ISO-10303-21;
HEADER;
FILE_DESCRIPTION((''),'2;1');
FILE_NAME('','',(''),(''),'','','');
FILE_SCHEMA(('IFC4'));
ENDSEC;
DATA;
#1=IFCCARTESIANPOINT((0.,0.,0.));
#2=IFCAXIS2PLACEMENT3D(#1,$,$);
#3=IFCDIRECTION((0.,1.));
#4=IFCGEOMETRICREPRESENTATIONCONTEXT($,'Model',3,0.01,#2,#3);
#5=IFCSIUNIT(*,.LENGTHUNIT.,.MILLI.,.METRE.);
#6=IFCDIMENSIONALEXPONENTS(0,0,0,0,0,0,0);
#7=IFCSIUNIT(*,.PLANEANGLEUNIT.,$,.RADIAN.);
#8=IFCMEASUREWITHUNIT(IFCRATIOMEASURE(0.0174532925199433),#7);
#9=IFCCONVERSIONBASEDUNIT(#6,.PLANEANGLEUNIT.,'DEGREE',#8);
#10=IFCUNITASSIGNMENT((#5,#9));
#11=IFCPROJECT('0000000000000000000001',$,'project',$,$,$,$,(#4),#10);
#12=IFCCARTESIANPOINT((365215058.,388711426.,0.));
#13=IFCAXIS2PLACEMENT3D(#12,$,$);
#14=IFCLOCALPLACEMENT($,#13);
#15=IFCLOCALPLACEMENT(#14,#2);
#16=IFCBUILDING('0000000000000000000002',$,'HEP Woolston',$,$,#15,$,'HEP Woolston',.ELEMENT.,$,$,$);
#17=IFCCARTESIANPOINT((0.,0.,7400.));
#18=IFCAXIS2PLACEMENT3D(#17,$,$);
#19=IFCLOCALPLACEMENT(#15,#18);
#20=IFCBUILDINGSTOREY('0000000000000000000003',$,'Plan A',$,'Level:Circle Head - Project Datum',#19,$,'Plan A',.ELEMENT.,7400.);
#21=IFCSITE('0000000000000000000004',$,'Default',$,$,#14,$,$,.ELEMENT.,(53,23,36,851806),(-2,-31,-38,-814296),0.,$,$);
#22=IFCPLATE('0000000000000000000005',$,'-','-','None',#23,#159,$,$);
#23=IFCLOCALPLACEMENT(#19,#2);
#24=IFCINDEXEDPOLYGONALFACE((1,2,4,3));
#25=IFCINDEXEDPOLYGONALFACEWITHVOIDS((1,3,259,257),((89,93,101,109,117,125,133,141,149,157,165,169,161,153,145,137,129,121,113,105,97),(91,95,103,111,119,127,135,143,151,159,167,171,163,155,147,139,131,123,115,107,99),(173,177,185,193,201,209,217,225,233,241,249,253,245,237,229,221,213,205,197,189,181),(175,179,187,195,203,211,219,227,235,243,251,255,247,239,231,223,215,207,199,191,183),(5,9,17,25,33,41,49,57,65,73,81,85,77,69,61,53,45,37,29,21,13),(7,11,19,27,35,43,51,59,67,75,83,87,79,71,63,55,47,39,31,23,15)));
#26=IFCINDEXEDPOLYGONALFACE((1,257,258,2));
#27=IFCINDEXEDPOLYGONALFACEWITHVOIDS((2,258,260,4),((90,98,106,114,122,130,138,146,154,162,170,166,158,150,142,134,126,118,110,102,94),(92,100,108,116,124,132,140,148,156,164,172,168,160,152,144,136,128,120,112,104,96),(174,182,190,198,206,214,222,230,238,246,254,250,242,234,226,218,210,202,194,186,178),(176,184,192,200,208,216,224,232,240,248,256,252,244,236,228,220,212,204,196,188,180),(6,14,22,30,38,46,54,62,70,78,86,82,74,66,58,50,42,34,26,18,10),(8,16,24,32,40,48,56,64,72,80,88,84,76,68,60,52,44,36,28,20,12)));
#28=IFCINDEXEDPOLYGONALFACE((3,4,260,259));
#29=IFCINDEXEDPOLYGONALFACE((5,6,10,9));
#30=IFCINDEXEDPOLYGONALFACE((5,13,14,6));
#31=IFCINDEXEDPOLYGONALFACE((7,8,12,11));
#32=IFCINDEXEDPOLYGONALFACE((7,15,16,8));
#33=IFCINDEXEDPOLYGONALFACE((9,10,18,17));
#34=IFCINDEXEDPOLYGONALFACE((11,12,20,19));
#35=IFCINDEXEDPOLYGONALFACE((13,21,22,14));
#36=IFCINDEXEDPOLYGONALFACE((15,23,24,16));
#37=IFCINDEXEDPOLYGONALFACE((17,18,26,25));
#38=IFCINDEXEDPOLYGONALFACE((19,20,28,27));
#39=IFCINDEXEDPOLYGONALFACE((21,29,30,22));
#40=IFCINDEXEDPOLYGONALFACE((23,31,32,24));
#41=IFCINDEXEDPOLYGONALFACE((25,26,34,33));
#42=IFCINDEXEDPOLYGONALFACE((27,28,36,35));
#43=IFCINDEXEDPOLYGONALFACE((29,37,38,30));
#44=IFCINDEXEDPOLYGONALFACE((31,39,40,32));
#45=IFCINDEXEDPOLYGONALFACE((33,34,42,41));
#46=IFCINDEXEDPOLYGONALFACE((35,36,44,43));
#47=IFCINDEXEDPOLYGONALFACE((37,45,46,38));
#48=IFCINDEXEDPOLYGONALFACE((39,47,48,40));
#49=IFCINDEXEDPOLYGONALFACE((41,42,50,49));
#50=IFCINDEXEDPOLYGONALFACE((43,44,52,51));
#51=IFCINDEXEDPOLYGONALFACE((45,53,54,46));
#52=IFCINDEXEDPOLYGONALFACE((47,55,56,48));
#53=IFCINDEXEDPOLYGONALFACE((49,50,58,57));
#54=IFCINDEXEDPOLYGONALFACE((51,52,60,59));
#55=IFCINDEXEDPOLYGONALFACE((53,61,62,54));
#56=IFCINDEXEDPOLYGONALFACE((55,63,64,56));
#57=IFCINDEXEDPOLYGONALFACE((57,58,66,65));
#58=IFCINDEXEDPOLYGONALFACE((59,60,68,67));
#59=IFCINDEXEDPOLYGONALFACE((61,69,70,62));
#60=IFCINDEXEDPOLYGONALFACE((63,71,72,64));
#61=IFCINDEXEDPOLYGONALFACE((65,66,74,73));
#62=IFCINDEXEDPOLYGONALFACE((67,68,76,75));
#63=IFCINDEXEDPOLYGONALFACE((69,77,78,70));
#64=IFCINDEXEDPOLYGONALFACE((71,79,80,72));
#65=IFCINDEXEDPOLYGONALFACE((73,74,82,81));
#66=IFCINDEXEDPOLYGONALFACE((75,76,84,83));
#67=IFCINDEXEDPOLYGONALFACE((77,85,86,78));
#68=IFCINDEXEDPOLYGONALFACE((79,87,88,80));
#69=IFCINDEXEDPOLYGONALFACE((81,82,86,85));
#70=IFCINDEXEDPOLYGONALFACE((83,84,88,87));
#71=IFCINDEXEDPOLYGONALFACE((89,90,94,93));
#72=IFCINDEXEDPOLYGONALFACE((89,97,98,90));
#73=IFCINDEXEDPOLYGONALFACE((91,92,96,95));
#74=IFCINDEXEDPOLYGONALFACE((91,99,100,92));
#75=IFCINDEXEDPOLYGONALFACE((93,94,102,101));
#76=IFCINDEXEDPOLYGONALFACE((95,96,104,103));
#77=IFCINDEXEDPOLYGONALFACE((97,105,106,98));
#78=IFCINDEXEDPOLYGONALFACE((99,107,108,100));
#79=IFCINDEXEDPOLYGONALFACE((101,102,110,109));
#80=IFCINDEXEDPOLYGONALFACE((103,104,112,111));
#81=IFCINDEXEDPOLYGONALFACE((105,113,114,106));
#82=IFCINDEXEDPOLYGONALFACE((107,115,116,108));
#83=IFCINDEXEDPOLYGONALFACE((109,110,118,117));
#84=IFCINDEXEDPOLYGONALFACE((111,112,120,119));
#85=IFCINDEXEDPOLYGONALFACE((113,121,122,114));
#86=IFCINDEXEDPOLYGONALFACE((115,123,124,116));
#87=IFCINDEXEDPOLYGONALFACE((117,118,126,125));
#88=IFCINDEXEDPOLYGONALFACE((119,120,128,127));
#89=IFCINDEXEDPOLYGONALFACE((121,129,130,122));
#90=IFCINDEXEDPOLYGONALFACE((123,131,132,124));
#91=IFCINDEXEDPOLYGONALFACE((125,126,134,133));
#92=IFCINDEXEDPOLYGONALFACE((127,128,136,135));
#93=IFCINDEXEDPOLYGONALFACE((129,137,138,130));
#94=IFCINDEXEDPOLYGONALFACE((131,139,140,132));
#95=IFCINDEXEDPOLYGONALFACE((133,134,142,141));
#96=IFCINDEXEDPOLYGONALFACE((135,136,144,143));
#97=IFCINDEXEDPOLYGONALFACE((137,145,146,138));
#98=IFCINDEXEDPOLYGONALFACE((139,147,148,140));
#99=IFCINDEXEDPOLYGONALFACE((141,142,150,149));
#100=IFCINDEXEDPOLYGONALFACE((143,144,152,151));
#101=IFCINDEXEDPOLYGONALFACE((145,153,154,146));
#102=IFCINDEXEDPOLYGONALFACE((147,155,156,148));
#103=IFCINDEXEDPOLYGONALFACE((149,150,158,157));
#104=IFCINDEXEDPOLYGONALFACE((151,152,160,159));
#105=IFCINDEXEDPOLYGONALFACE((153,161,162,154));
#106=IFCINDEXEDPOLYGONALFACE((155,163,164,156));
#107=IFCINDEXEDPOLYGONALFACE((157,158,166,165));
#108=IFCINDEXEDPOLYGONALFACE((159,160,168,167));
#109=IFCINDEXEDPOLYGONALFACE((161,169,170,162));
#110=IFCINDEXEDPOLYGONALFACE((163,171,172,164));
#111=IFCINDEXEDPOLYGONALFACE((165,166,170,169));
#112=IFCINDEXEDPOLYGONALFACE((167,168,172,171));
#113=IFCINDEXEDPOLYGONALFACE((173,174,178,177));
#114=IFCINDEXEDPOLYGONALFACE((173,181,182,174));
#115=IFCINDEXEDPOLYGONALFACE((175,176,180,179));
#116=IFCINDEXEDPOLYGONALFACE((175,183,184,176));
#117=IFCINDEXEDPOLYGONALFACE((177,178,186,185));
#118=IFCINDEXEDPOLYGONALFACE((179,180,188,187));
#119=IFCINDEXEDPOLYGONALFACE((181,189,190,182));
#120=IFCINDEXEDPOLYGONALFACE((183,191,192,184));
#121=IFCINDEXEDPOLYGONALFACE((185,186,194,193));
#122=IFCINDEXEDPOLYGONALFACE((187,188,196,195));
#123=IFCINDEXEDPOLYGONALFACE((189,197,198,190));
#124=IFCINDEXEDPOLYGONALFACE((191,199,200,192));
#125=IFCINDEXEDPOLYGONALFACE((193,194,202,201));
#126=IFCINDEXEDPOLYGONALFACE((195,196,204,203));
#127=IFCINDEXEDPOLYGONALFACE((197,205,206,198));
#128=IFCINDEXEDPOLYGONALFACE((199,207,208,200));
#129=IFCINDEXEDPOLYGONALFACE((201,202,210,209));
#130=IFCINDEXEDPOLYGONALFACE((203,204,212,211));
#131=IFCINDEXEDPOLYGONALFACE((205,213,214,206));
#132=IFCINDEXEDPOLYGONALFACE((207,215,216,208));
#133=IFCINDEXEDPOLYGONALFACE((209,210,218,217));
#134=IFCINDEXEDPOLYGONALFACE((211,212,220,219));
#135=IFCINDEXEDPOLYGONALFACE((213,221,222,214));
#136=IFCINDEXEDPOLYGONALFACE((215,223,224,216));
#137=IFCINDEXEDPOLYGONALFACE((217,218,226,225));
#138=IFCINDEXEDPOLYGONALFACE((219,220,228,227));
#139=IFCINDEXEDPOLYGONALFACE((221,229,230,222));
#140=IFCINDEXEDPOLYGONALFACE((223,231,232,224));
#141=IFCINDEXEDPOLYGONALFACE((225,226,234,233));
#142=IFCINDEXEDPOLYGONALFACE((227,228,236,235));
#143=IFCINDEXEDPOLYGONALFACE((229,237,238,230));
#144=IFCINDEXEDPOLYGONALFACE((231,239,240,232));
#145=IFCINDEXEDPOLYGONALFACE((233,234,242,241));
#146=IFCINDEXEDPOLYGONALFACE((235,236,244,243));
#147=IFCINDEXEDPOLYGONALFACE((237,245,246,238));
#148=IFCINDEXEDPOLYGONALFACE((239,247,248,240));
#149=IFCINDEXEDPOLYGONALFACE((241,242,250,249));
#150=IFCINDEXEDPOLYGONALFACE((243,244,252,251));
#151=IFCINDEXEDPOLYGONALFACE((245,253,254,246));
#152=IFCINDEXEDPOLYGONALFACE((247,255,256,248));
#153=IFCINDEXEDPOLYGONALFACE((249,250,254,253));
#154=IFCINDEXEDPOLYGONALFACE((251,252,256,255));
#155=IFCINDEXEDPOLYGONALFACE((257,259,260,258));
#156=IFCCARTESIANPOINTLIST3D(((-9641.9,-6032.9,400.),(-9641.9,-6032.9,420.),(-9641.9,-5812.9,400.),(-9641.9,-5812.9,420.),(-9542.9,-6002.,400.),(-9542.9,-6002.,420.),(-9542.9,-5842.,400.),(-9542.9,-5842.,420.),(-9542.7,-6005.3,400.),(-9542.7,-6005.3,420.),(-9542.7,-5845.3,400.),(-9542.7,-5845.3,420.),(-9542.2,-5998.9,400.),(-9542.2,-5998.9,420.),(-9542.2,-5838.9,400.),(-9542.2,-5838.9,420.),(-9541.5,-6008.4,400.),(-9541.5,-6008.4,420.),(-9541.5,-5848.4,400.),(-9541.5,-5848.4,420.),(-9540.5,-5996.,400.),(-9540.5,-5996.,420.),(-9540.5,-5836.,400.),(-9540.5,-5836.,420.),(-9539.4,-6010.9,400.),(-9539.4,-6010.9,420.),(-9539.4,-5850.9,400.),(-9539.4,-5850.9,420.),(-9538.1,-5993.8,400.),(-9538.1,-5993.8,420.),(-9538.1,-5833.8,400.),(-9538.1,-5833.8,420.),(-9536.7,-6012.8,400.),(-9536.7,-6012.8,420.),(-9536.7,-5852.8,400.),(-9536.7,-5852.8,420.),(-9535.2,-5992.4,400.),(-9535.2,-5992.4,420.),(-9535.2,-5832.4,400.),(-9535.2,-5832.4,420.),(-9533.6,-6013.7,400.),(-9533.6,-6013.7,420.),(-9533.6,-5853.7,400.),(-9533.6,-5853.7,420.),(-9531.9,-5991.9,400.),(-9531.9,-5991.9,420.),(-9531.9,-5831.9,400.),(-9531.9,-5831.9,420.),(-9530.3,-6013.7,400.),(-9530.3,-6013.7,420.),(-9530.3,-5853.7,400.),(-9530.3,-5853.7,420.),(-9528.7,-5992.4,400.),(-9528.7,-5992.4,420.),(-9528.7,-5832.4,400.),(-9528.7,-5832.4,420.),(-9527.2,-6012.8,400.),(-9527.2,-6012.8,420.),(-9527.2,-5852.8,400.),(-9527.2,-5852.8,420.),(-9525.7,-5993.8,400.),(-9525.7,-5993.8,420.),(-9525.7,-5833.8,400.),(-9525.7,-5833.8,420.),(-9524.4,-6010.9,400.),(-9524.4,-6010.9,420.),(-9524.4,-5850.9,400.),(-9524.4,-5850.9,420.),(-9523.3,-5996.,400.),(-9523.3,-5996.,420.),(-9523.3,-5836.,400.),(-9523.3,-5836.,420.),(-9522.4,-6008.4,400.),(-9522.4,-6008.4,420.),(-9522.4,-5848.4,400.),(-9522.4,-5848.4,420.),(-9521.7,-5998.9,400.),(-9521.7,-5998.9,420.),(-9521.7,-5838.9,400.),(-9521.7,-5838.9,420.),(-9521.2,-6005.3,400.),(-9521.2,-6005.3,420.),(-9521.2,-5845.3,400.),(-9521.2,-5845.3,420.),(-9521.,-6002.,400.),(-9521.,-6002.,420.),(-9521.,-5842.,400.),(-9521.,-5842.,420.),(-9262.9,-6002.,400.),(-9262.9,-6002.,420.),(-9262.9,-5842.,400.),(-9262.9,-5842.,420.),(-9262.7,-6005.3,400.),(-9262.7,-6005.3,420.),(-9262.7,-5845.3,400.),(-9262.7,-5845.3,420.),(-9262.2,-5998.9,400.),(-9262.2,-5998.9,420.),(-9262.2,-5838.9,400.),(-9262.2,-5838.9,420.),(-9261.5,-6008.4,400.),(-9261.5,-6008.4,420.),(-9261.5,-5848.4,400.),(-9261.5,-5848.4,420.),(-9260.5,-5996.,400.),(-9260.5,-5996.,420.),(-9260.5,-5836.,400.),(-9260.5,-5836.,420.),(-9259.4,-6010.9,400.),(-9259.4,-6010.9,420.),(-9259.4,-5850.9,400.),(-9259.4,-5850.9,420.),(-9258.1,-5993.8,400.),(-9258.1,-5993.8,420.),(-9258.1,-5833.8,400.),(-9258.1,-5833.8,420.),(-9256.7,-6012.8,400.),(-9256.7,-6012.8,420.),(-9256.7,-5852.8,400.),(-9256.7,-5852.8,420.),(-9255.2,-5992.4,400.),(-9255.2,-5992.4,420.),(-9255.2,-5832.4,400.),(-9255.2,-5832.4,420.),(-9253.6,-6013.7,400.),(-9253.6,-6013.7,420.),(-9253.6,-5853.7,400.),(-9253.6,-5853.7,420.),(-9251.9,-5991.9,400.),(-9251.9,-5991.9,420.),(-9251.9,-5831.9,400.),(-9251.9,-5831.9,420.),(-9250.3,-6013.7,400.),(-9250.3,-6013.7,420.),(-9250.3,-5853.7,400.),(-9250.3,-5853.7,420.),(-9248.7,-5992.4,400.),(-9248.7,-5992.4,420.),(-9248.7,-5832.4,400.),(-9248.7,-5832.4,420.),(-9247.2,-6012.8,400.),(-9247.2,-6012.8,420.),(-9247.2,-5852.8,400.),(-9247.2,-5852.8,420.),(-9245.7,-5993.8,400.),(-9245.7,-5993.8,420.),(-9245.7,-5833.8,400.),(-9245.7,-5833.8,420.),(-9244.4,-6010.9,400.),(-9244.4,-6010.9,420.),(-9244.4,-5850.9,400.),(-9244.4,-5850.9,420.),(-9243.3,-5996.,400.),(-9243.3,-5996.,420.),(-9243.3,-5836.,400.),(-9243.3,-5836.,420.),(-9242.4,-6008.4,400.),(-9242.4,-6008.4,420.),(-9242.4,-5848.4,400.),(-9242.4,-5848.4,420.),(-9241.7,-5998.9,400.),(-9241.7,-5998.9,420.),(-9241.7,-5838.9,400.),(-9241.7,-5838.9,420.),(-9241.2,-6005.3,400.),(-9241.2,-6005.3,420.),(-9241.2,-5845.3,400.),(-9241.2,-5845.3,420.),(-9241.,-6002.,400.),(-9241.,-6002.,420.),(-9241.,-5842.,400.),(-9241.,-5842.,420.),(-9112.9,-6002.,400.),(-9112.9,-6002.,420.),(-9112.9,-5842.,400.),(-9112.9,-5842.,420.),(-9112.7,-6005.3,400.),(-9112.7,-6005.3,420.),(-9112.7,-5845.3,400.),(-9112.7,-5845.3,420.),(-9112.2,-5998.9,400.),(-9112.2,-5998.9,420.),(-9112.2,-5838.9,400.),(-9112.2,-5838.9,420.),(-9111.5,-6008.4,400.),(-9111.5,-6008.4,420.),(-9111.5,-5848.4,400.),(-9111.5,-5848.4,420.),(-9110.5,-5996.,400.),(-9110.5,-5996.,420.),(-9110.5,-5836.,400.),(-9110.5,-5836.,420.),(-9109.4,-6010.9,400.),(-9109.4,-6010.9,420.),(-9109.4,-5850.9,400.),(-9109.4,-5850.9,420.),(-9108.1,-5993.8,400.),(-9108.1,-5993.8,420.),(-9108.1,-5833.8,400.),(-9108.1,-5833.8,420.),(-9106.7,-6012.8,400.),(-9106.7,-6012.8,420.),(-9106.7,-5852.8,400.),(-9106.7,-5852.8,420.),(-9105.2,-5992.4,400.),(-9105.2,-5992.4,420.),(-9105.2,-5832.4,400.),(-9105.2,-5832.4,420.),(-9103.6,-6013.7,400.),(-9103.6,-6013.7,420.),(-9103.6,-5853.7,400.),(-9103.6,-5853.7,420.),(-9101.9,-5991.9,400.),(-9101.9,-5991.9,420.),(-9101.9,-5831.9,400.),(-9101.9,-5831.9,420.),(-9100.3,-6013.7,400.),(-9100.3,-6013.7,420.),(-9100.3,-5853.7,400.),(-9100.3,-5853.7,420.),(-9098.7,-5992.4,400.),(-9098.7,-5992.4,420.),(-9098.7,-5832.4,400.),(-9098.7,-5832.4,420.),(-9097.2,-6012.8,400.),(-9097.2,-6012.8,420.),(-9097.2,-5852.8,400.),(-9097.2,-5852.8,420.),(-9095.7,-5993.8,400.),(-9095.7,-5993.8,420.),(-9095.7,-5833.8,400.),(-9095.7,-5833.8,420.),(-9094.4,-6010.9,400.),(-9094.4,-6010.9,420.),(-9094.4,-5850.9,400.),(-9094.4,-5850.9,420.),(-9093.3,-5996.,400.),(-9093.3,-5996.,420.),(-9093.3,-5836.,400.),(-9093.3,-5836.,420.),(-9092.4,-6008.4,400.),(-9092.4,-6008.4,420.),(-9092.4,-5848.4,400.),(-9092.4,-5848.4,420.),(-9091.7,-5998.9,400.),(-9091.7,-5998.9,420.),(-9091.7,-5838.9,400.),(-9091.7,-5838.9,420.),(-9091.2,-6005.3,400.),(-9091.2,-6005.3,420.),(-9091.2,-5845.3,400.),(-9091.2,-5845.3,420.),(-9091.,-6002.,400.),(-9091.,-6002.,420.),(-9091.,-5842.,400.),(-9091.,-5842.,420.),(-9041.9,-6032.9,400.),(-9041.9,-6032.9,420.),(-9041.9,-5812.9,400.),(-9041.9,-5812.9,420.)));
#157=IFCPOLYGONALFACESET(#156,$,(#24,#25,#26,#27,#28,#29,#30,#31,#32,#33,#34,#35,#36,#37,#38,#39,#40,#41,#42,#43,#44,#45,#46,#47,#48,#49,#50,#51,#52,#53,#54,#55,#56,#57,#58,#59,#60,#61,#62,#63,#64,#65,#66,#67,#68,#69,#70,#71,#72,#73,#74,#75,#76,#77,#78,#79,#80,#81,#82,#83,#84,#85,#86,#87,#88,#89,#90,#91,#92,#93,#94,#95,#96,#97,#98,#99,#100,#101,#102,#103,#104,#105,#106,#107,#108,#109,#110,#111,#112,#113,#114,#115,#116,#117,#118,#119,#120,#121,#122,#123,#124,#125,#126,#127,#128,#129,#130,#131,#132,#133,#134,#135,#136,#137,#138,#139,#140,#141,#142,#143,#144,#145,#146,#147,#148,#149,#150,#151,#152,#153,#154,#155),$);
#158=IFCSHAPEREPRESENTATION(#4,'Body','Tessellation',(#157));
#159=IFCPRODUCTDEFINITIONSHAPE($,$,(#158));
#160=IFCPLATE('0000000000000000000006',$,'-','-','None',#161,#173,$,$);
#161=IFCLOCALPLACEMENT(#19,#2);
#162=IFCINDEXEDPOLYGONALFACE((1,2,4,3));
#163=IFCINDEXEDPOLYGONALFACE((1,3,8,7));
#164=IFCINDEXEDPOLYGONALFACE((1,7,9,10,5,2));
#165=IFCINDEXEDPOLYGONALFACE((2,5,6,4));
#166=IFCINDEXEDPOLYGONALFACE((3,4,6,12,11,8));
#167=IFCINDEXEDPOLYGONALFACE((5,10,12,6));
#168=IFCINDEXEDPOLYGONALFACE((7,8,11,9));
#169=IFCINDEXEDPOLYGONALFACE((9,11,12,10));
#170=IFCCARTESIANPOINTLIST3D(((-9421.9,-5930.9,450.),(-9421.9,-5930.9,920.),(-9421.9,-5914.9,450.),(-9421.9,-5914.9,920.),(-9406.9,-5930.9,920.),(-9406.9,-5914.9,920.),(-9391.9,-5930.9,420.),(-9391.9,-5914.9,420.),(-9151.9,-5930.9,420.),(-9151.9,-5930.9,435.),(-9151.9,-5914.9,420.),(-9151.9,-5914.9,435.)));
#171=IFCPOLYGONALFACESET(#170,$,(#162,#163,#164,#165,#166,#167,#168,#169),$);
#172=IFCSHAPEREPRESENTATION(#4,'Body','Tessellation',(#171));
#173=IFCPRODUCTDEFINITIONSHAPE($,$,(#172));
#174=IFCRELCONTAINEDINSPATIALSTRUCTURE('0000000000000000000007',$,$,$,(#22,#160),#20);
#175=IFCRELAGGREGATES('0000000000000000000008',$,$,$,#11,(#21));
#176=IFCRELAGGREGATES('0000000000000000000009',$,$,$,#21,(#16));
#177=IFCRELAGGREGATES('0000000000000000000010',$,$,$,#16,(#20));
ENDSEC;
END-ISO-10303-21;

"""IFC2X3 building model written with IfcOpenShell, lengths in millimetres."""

from ifc_helpers import new_model, entity, si_unit, converted_unit, direction, frame, frame_2d, origin, origin_with_axes, place, context, project, spatial, polyline, circle, outline, extrude, element, save


model = new_model("IFC2X3")

# Units and contexts
model_context = context("Model", 3, precision=0.01, world=origin(), true_north=direction((0.0, 1.0)))
ifc_project = project(units=[si_unit("LENGTHUNIT", "METRE", prefix="MILLI"), converted_unit("PLANEANGLEUNIT", "DEGREE", entity("IfcRatioMeasure", 0.0174532925199433), si_unit("PLANEANGLEUNIT", "RADIAN"), dimensions=[0, 0, 0, 0, 0, 0, 0])], contexts=[model_context])

# Site, building, storey
site_placement = place(None, frame((365215058.0, 388711426.0, 0.0)))
site = spatial("IfcSite", under=ifc_project, at=site_placement, Name="Default", CompositionType="ELEMENT", RefLatitude=(53, 23, 36, 851806), RefLongitude=(-2, -31, -38, -814296), RefElevation=0.0)
building_placement = place(site_placement, origin())
building = spatial("IfcBuilding", under=site, at=building_placement, Name="HEP Woolston", LongName="HEP Woolston", CompositionType="ELEMENT")
storey_placement = place(building_placement, frame((0.0, 0.0, 7400.0)))
storey = spatial("IfcBuildingStorey", under=building, at=storey_placement, Name="Plan A", ObjectType="Level:Circle Head - Project Datum", LongName="Plan A", CompositionType="ELEMENT", Elevation=7400.0)

# Plate, openings
plate_1_placement = place(storey_placement, frame((-9041.9, -5812.9, 400.0)))
plate_1 = element("IfcPlate", 1, at=plate_1_placement, inside=storey, Name="-", Description="-", ObjectType="None", context=model_context, shape_type="SweptSolid", body=[
    extrude(outline(polyline([(0.0, 0.0), (-600.0, 0.0), (-600.0, -220.0), (0.0, -220.0), (0.0, 0.0)])), origin_with_axes(), (0.0, 0.0, 1.0), 20.0),
])
opening_1_placement = place(plate_1_placement, frame((-490.0, -110.0, -0.5), z_axis=(0.0, 0.0, 1.0), x_axis=(0.0, 1.0, 0.0)))
element("IfcOpeningElement", 2, at=opening_1_placement, cuts=plate_1, ObjectType="Opening", context=model_context, shape_type="SweptSolid", body=[
    extrude(circle(Radius=11.0, at=frame_2d((80.0, 0.0), x_axis=(1.0, 0.0))), origin(), (0.0, 0.0, 1.0), 21.0),
])
opening_2_placement = place(plate_1_placement, frame((-490.0, -110.0, -0.5), z_axis=(0.0, 0.0, 1.0), x_axis=(0.0, 1.0, 0.0)))
element("IfcOpeningElement", 3, at=opening_2_placement, cuts=plate_1, ObjectType="Opening", context=model_context, shape_type="SweptSolid", body=[
    extrude(circle(Radius=11.0, at=frame_2d((-80.0, 0.0), x_axis=(1.0, 0.0))), origin(), (0.0, 0.0, 1.0), 21.0),
])
opening_3_placement = place(plate_1_placement, frame((-135.0, -110.0, -0.5), z_axis=(0.0, 0.0, 1.0), x_axis=(0.0, 1.0, 0.0)))
element("IfcOpeningElement", 4, at=opening_3_placement, cuts=plate_1, ObjectType="Opening", context=model_context, shape_type="SweptSolid", body=[
    extrude(circle(Radius=11.0, at=frame_2d((80.0, 75.0), x_axis=(1.0, 0.0))), origin(), (0.0, 0.0, 1.0), 21.0),
])
opening_4_placement = place(plate_1_placement, frame((-135.0, -110.0, -0.5), z_axis=(0.0, 0.0, 1.0), x_axis=(0.0, 1.0, 0.0)))
element("IfcOpeningElement", 5, at=opening_4_placement, cuts=plate_1, ObjectType="Opening", context=model_context, shape_type="SweptSolid", body=[
    extrude(circle(Radius=11.0, at=frame_2d((-80.0, 75.0), x_axis=(1.0, 0.0))), origin(), (0.0, 0.0, 1.0), 21.0),
])
opening_5_placement = place(plate_1_placement, frame((-135.0, -110.0, -0.5), z_axis=(0.0, 0.0, 1.0), x_axis=(0.0, 1.0, 0.0)))
element("IfcOpeningElement", 6, at=opening_5_placement, cuts=plate_1, ObjectType="Opening", context=model_context, shape_type="SweptSolid", body=[
    extrude(circle(Radius=11.0, at=frame_2d((80.0, -75.0), x_axis=(1.0, 0.0))), origin(), (0.0, 0.0, 1.0), 21.0),
])
opening_6_placement = place(plate_1_placement, frame((-135.0, -110.0, -0.5), z_axis=(0.0, 0.0, 1.0), x_axis=(0.0, 1.0, 0.0)))
element("IfcOpeningElement", 7, at=opening_6_placement, cuts=plate_1, ObjectType="Opening", context=model_context, shape_type="SweptSolid", body=[
    extrude(circle(Radius=11.0, at=frame_2d((-80.0, -75.0), x_axis=(1.0, 0.0))), origin(), (0.0, 0.0, 1.0), 21.0),
])

# Plate
plate_2_placement = place(storey_placement, frame((-9421.9, -5914.9, 920.0), z_axis=(0.0, -1.0, 0.0), x_axis=(1.0, 0.0, 0.0)))
element("IfcPlate", 8, at=plate_2_placement, inside=storey, Name="-", Description="-", ObjectType="None", context=model_context, shape_type="SweptSolid", body=[
    extrude(outline(polyline([(0.0, -470.0), (30.0, -500.0), (270.0, -500.0), (270.0, -485.0), (15.0, 0.0), (0.0, 0.0), (0.0, -470.0)])), origin_with_axes(), (0.0, 0.0, 1.0), 16.0),
])

save(model, "model.ifc")
